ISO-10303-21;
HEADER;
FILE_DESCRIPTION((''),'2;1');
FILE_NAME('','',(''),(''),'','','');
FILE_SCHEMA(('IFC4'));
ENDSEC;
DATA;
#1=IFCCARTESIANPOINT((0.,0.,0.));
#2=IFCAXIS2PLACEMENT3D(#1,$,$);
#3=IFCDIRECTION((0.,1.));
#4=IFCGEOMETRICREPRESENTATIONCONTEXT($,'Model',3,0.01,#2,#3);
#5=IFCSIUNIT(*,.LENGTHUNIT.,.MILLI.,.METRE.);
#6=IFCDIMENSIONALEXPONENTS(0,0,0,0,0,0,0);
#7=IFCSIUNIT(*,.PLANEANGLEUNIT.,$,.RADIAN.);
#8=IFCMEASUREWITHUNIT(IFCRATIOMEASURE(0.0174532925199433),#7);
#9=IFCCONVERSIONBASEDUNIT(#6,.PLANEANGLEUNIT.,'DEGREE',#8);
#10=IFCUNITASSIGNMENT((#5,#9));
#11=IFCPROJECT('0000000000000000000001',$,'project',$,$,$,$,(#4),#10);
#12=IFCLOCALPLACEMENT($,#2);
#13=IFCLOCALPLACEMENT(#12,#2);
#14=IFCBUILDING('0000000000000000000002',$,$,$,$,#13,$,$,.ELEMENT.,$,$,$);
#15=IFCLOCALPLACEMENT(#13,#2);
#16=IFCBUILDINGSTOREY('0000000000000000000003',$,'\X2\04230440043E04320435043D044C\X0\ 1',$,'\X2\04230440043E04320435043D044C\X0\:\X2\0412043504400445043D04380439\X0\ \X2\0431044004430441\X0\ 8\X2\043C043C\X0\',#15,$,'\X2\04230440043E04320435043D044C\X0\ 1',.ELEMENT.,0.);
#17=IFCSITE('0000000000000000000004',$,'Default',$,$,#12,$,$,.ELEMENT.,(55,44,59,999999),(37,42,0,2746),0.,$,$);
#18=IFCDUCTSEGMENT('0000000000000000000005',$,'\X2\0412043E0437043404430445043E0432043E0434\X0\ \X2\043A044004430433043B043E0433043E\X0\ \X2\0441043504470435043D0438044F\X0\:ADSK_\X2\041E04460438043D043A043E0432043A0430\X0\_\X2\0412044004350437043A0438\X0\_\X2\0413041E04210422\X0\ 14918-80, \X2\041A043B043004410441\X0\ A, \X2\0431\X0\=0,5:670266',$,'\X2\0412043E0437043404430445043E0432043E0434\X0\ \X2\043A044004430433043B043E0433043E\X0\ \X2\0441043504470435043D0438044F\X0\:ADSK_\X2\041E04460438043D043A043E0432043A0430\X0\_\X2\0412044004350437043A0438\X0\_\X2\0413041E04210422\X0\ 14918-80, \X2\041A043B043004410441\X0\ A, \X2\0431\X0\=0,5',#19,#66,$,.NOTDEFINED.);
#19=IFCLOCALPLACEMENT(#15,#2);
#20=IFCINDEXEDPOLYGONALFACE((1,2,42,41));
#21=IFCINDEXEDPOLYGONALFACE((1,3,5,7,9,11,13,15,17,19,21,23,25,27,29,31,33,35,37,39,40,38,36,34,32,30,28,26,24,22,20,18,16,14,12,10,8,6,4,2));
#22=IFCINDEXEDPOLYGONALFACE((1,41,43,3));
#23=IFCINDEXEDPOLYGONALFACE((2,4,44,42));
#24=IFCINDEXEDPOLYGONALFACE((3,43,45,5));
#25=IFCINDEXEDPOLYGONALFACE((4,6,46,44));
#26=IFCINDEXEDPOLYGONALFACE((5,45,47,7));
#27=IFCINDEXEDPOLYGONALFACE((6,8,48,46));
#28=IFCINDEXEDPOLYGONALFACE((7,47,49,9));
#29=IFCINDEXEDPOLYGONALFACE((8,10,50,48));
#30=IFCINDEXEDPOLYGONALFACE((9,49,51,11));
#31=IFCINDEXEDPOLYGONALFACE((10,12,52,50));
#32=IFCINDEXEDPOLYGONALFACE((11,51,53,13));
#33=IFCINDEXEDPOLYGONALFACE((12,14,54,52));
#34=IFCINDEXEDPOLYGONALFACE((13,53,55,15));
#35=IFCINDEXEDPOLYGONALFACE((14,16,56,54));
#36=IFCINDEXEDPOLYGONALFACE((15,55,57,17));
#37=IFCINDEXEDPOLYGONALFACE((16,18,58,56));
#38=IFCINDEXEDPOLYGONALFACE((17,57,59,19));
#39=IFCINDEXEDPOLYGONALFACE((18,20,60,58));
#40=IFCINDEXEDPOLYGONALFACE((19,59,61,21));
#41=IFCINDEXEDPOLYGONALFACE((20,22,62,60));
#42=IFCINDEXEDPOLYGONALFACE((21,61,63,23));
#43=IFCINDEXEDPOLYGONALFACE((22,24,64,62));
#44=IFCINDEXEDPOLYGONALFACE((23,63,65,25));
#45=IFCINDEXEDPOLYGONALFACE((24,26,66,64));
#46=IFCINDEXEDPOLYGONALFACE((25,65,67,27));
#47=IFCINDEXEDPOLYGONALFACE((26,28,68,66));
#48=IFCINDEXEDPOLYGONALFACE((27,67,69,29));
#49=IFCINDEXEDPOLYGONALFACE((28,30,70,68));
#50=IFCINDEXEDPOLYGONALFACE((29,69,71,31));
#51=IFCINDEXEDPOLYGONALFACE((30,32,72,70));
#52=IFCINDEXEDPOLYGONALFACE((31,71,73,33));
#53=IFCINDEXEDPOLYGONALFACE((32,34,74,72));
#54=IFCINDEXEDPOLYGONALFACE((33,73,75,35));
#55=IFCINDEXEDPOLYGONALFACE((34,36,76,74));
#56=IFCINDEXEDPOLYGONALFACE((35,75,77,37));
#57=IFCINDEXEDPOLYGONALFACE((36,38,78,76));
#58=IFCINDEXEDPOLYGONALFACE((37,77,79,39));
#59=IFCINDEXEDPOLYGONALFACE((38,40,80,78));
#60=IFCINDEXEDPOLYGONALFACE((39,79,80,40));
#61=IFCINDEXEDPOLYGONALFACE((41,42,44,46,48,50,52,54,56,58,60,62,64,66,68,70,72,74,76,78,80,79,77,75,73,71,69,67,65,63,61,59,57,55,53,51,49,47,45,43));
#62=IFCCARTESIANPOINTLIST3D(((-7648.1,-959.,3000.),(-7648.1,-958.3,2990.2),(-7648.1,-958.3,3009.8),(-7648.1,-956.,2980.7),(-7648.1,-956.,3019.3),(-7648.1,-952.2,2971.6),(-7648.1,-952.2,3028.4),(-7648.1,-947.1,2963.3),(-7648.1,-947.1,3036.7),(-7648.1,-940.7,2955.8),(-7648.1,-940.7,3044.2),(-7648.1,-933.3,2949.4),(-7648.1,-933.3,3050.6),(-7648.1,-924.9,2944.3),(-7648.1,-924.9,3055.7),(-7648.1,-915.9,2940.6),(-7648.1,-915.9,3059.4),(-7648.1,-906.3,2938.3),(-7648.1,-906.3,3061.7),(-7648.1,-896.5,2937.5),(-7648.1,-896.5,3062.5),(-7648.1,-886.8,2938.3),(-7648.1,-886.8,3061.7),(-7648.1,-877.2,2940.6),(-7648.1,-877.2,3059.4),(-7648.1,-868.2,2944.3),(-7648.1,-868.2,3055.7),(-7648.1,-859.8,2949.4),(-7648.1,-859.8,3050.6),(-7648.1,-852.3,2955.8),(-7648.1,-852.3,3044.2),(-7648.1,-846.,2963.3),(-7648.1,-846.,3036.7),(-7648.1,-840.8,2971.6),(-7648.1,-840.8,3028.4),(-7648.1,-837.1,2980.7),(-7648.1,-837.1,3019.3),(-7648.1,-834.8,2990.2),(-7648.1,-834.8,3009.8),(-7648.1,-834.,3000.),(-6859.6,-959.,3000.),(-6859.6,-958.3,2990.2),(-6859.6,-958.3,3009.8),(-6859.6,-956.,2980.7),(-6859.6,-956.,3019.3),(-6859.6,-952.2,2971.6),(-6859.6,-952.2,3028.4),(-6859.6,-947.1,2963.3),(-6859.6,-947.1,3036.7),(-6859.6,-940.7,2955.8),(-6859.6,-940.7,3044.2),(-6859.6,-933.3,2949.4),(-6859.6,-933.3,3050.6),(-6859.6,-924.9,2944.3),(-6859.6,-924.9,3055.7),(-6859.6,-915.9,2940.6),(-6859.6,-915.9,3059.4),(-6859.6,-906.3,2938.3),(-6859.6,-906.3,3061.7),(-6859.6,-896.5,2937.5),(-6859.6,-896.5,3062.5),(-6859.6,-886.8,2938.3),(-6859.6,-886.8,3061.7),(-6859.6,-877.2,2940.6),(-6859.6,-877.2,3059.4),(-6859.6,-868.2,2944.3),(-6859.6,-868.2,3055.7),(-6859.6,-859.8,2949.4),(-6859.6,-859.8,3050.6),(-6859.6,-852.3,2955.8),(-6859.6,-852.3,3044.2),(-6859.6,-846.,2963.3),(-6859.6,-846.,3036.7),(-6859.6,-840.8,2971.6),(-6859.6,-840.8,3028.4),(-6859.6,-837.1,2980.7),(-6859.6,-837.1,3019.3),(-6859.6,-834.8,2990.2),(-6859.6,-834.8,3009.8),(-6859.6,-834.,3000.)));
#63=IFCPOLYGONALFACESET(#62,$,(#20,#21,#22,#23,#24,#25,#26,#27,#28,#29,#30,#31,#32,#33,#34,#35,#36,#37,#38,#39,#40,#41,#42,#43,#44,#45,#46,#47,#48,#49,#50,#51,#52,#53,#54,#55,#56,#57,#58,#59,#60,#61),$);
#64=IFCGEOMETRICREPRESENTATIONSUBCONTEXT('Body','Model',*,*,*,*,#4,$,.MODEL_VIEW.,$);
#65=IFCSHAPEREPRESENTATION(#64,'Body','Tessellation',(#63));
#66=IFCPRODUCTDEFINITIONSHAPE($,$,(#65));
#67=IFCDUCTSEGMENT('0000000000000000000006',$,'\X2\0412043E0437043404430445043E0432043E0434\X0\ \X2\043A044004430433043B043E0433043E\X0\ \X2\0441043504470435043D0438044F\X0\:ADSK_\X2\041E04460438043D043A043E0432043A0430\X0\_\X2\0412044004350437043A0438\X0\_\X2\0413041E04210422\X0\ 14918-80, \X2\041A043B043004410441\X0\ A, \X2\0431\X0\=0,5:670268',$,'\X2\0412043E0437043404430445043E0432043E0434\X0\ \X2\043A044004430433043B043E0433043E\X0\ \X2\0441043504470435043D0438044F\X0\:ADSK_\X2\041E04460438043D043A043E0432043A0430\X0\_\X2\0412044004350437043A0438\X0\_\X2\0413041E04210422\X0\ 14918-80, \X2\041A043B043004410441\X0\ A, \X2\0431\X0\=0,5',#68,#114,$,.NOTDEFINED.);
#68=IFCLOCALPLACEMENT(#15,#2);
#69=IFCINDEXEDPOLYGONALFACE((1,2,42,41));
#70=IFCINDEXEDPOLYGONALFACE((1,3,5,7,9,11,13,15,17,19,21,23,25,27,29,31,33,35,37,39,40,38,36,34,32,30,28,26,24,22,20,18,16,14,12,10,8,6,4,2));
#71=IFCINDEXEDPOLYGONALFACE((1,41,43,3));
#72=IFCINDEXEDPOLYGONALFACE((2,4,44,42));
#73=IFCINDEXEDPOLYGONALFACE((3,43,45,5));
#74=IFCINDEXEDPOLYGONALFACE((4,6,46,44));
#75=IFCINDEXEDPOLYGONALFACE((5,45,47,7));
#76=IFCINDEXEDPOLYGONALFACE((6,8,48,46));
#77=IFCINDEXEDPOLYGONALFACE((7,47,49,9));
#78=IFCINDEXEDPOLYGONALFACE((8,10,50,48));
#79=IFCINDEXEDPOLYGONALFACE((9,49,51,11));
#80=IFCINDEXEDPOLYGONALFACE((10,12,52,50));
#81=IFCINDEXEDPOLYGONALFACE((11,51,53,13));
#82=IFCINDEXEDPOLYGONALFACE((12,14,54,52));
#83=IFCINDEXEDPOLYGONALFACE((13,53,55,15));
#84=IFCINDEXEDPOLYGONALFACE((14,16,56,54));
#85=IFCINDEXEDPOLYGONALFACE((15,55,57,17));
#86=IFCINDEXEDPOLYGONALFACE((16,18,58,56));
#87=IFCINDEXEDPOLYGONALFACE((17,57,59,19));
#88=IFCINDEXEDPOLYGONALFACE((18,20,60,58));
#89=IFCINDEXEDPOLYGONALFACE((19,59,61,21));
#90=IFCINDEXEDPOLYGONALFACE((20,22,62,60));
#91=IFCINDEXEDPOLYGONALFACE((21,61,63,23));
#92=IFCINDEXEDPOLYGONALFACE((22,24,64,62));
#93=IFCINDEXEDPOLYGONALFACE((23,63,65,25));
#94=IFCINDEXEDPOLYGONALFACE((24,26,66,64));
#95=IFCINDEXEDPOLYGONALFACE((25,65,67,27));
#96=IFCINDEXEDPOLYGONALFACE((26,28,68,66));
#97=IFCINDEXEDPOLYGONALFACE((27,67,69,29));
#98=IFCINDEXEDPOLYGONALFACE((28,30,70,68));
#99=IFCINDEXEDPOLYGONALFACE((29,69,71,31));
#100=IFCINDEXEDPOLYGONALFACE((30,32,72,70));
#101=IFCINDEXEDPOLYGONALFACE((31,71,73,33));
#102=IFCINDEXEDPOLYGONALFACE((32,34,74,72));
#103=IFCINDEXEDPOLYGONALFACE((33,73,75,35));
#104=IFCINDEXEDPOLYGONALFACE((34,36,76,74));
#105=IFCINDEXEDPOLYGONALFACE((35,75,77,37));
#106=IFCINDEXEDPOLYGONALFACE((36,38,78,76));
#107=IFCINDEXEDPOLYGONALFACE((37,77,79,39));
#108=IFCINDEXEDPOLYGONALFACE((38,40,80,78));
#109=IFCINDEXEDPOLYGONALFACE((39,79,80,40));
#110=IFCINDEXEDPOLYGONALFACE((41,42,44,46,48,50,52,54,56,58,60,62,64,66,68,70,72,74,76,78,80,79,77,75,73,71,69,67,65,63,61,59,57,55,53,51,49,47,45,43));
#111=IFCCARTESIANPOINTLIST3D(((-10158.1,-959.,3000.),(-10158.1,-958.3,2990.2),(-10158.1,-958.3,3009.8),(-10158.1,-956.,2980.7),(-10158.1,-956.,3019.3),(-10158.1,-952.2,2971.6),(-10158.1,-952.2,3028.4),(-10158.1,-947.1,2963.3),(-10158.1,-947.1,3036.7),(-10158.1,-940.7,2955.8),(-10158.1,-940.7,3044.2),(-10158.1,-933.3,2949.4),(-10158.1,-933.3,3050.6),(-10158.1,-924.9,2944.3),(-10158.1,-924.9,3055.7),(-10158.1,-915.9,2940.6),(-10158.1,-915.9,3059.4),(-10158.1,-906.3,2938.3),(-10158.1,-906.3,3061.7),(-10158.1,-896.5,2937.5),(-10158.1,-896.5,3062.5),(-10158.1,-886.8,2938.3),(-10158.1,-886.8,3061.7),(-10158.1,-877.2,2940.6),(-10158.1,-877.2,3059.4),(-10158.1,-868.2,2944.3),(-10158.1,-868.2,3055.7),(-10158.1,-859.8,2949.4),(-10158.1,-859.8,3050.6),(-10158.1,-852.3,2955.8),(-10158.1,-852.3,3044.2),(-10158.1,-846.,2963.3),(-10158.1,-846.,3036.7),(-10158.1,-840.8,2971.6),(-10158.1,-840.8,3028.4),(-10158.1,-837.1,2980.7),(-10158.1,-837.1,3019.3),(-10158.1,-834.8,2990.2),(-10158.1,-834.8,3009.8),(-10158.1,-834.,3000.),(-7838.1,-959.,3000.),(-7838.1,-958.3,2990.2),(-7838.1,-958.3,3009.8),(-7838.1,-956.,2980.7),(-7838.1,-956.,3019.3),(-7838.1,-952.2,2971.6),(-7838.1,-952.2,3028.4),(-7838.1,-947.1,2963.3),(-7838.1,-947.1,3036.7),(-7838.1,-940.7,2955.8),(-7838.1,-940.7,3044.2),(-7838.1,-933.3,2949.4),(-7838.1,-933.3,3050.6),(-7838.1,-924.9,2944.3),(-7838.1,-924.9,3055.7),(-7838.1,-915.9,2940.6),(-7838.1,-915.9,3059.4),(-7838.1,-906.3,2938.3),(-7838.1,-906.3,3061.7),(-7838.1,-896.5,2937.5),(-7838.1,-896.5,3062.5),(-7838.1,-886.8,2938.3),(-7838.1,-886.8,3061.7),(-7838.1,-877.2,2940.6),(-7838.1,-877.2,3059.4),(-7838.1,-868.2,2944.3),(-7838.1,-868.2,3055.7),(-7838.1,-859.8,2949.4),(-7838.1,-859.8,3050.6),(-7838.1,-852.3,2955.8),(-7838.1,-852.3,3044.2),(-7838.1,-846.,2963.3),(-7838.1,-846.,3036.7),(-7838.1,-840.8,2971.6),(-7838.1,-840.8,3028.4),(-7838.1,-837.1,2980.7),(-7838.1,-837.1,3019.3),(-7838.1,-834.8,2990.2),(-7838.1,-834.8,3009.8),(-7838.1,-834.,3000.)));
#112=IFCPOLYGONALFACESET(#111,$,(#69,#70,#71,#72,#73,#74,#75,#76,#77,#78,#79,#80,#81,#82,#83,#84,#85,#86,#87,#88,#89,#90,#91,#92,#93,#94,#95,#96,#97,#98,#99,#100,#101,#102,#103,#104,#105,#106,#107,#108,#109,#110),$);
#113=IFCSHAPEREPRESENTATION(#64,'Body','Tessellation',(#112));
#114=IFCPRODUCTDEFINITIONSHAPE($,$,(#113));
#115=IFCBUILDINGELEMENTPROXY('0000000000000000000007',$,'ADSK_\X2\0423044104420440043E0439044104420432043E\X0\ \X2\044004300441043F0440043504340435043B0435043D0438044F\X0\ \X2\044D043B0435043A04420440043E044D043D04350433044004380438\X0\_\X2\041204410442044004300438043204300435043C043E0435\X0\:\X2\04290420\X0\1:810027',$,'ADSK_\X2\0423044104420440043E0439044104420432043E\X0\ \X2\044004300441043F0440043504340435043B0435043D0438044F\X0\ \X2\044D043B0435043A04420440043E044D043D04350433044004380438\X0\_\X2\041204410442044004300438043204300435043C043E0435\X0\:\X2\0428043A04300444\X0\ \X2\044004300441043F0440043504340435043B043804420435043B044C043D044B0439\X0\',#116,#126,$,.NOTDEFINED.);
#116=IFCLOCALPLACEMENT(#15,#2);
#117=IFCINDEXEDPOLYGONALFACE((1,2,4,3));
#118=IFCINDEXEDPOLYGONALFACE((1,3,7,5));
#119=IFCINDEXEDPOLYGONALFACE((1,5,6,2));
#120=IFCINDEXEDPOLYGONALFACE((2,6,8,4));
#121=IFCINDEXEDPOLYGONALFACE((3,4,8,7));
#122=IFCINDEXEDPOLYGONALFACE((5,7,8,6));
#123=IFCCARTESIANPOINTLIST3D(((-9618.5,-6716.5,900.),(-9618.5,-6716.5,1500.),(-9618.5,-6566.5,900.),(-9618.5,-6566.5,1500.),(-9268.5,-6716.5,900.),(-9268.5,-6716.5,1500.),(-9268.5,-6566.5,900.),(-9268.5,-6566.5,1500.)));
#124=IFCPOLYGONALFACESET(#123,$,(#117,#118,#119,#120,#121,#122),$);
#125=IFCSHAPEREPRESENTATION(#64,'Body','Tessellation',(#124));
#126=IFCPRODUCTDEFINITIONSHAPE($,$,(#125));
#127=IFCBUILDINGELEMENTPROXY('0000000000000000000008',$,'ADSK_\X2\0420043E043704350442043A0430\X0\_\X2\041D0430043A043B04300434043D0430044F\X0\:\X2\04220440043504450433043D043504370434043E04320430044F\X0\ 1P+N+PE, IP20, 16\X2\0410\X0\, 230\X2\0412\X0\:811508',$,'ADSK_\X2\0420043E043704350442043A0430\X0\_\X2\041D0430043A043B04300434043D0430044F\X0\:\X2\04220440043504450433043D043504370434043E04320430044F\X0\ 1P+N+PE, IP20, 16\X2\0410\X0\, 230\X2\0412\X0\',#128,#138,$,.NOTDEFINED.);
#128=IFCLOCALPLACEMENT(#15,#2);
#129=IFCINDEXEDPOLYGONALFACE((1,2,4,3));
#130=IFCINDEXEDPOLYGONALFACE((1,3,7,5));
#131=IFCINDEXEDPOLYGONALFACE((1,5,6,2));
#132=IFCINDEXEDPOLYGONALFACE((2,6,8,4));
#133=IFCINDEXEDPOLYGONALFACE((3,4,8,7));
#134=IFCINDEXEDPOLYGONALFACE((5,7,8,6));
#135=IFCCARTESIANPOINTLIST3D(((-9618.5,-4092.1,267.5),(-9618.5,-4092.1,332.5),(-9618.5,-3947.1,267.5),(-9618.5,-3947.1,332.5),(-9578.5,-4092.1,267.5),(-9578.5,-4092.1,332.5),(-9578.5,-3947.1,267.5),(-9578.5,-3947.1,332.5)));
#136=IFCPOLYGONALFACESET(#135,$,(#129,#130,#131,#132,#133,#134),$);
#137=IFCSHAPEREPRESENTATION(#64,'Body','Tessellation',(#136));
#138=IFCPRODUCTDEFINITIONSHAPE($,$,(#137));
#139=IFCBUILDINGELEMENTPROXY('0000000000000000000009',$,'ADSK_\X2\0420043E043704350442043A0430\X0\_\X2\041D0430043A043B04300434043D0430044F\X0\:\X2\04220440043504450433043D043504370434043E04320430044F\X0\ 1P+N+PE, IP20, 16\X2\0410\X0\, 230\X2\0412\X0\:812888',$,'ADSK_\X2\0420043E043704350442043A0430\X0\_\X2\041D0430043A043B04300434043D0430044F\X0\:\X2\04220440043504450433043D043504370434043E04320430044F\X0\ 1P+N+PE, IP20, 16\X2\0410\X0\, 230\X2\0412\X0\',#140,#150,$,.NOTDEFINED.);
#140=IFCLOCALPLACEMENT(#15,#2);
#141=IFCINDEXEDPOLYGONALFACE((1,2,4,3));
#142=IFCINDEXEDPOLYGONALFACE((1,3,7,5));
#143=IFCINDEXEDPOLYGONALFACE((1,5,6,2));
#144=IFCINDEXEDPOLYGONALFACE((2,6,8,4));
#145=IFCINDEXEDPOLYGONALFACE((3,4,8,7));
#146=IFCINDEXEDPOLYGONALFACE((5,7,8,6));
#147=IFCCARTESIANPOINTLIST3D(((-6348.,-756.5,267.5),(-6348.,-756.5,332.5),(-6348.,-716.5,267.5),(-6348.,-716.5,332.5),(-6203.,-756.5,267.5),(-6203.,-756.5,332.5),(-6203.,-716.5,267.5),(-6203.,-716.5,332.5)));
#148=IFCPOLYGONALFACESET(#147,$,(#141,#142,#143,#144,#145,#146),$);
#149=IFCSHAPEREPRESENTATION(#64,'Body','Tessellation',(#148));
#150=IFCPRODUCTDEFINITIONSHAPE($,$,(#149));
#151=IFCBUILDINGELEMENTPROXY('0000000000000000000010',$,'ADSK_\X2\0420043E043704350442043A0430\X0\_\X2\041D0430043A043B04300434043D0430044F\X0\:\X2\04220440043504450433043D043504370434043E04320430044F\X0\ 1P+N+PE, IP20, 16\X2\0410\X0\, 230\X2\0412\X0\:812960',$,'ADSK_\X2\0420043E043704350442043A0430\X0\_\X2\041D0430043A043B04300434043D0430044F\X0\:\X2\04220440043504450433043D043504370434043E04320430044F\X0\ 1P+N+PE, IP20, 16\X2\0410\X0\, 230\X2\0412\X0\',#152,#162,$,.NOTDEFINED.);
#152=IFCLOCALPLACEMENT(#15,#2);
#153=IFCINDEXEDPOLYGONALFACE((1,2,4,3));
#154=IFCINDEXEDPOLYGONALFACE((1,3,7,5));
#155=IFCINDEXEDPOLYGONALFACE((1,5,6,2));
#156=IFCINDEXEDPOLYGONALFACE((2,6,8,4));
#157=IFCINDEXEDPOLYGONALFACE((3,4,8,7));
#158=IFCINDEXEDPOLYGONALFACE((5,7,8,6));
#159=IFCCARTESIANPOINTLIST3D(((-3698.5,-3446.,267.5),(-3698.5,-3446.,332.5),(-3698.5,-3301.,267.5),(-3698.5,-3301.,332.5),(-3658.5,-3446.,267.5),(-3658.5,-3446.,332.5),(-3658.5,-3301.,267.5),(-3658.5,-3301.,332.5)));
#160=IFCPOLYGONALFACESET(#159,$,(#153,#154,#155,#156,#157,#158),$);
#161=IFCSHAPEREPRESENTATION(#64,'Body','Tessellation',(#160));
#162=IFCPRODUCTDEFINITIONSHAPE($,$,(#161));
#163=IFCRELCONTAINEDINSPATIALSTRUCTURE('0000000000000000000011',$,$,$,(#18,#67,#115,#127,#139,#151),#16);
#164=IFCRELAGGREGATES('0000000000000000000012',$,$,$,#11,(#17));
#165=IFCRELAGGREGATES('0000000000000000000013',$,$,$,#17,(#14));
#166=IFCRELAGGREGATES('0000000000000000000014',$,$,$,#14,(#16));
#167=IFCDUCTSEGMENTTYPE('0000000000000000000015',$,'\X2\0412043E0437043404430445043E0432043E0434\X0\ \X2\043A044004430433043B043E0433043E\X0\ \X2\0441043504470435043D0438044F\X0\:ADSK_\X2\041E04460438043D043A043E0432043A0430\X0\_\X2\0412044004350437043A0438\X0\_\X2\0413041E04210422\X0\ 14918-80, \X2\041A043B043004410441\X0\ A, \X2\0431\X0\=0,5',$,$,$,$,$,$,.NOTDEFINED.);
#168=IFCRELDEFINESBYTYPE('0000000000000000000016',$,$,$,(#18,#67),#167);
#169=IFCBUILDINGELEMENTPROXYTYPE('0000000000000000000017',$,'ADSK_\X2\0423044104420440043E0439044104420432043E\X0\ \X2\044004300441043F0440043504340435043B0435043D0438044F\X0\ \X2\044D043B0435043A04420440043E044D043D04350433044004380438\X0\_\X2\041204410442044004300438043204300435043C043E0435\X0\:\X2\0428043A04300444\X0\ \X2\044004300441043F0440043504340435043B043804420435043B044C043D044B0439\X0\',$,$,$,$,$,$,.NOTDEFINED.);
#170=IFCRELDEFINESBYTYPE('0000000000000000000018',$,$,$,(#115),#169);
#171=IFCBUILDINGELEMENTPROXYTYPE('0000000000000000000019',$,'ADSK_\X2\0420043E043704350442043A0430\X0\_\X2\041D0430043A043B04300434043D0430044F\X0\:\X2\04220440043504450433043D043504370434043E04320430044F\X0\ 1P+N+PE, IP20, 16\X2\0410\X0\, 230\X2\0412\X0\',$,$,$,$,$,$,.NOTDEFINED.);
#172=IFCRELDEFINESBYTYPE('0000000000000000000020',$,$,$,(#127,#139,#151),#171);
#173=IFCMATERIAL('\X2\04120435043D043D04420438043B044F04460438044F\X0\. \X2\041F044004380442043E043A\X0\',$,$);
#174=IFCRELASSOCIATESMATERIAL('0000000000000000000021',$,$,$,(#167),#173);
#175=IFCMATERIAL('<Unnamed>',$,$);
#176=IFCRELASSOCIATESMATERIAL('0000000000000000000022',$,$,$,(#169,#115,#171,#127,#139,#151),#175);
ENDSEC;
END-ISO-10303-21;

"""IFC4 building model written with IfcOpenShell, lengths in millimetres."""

from ifc_helpers import new_model, entity, si_unit, converted_unit, direction, frame, origin, place, context, subcontext, project, spatial, indexed_curve, outline, extrude, source, transform, mapped, material, type_object, type_shapes, element, save


model = new_model("IFC4")

# Units and contexts
model_context = context("Model", 3, precision=0.01, world=origin(), true_north=direction((0.0, 1.0)))
body_context = subcontext(model_context, "Body", "Model", "MODEL_VIEW")
ifc_project = project(units=[si_unit("LENGTHUNIT", "METRE", prefix="MILLI"), converted_unit("PLANEANGLEUNIT", "DEGREE", entity("IfcRatioMeasure", 0.0174532925199433), si_unit("PLANEANGLEUNIT", "RADIAN"), dimensions=[0, 0, 0, 0, 0, 0, 0])], contexts=[model_context])

# Site, building, storey
site_placement = place(None, origin())
site = spatial("IfcSite", under=ifc_project, at=site_placement, Name="Default", CompositionType="ELEMENT", RefLatitude=(55, 44, 59, 999999), RefLongitude=(37, 42, 0, 2746), RefElevation=0.0)
building_placement = place(site_placement, origin())
building = spatial("IfcBuilding", under=site, at=building_placement, CompositionType="ELEMENT")
storey_placement = place(building_placement, origin())
storey = spatial("IfcBuildingStorey", under=building, at=storey_placement, Name="Уровень 1", ObjectType="Уровень:Верхний брус 8мм", LongName="Уровень 1", CompositionType="ELEMENT", Elevation=0.0)

# Duct segments
ifc_material_1 = material(Name="Веннтиляция. Приток")
duct_segment_type = type_object("IfcDuctSegmentType", Name="Воздуховод круглого сечения:ADSK_Оцинковка_Врезки_ГОСТ 14918-80, Класс A, б=0,5", PredefinedType="NOTDEFINED", material=ifc_material_1)
duct_segment_1_placement = place(storey_placement, origin())
element("IfcDuctSegment", 1, at=duct_segment_1_placement, inside=storey, type_object=duct_segment_type, Name="Воздуховод круглого сечения:ADSK_Оцинковка_Врезки_ГОСТ 14918-80, Класс A, б=0,5:670266", ObjectType="Воздуховод круглого сечения:ADSK_Оцинковка_Врезки_ГОСТ 14918-80, Класс A, б=0,5", PredefinedType="NOTDEFINED", context=body_context, shape_type="SweptSolid", body=[
    extrude(outline(indexed_curve([(62.5, 0.0), (61.7, 9.8), (59.4, 19.3), (55.7, 28.4), (50.6, 36.7), (44.2, 44.2), (36.7, 50.6), (28.4, 55.7), (19.3, 59.4), (9.8, 61.7), (0.0, 62.5), (-9.8, 61.7), (-19.3, 59.4), (-28.4, 55.7), (-36.7, 50.6), (-44.2, 44.2), (-50.6, 36.7), (-55.7, 28.4), (-59.4, 19.3), (-61.7, 9.8), (-62.5, 0.0), (-61.7, -9.8), (-59.4, -19.3), (-55.7, -28.4), (-50.6, -36.7), (-44.2, -44.2), (-36.7, -50.6), (-28.4, -55.7), (-19.3, -59.4), (-9.8, -61.7), (0.0, -62.5), (9.8, -61.7), (19.3, -59.4), (28.4, -55.7), (36.7, -50.6), (44.2, -44.2), (50.6, -36.7), (55.7, -28.4), (59.4, -19.3), (61.7, -9.8), (62.5, 0.0)], self_intersect=False)), frame((-7648.1, -896.5, 3000.0), z_axis=(1.0, 0.0, 0.0), x_axis=(0.0, 1.0, 0.0)), (0.0, 0.0, 1.0), 788.5),
])
duct_segment_2_placement = place(storey_placement, origin())
element("IfcDuctSegment", 2, at=duct_segment_2_placement, inside=storey, type_object=duct_segment_type, Name="Воздуховод круглого сечения:ADSK_Оцинковка_Врезки_ГОСТ 14918-80, Класс A, б=0,5:670268", ObjectType="Воздуховод круглого сечения:ADSK_Оцинковка_Врезки_ГОСТ 14918-80, Класс A, б=0,5", PredefinedType="NOTDEFINED", context=body_context, shape_type="SweptSolid", body=[
    extrude(outline(indexed_curve([(62.5, 0.0), (61.7, 9.8), (59.4, 19.3), (55.7, 28.4), (50.6, 36.7), (44.2, 44.2), (36.7, 50.6), (28.4, 55.7), (19.3, 59.4), (9.8, 61.7), (0.0, 62.5), (-9.8, 61.7), (-19.3, 59.4), (-28.4, 55.7), (-36.7, 50.6), (-44.2, 44.2), (-50.6, 36.7), (-55.7, 28.4), (-59.4, 19.3), (-61.7, 9.8), (-62.5, 0.0), (-61.7, -9.8), (-59.4, -19.3), (-55.7, -28.4), (-50.6, -36.7), (-44.2, -44.2), (-36.7, -50.6), (-28.4, -55.7), (-19.3, -59.4), (-9.8, -61.7), (0.0, -62.5), (9.8, -61.7), (19.3, -59.4), (28.4, -55.7), (36.7, -50.6), (44.2, -44.2), (50.6, -36.7), (55.7, -28.4), (59.4, -19.3), (61.7, -9.8), (62.5, 0.0)], self_intersect=False)), frame((-10158.1, -896.5, 3000.0), z_axis=(1.0, 0.0, 0.0), x_axis=(0.0, 1.0, 0.0)), (0.0, 0.0, 1.0), 2320.0),
])

# Building element proxies
ifc_material_2 = material(Name="<Unnamed>")
building_element_proxy_type_1 = type_object("IfcBuildingElementProxyType", Name="ADSK_Устройство распределения электроэнегрии_Встраиваемое:Шкаф распределительный", PredefinedType="NOTDEFINED", material=ifc_material_2)
shared_shape_1 = source(origin(), body_context, "Body", "SweptSolid", [
    extrude(outline(indexed_curve([(-75.0, -175.0), (75.0, -175.0), (75.0, 175.0), (-75.0, 175.0), (-75.0, -175.0)], self_intersect=False)), frame((0.0, -75.0, -600.0), z_axis=(0.0, 0.0, 1.0), x_axis=(0.0, 1.0, 0.0)), (0.0, 0.0, 1.0), 600.0),
])
type_shapes(building_element_proxy_type_1, [shared_shape_1])
proxy_placement = place(storey_placement, frame((-9443.5, -6566.5, 1500.0)))
element("IfcBuildingElementProxy", 3, at=proxy_placement, inside=storey, type_object=building_element_proxy_type_1, material=ifc_material_2, Name="ADSK_Устройство распределения электроэнегрии_Встраиваемое:ЩР1:810027", ObjectType="ADSK_Устройство распределения электроэнегрии_Встраиваемое:Шкаф распределительный", PredefinedType="NOTDEFINED", context=body_context, shape_type="MappedRepresentation", body=[
    mapped(shared_shape_1, transform((0.0, 0.0, 0.0), scale=1.0)),
])
building_element_proxy_type_2 = type_object("IfcBuildingElementProxyType", Name="ADSK_Розетка_Накладная:Трехгнездовая 1P+N+PE, IP20, 16А, 230В", PredefinedType="NOTDEFINED", material=ifc_material_2)
shared_shape_2 = source(origin(), body_context, "Body", "SweptSolid", [
    extrude(outline(indexed_curve([(-72.5, -20.0), (72.5, -20.0), (72.5, 20.0), (-72.5, 20.0), (-72.5, -20.0)], self_intersect=False)), frame((0.0, 20.0, -32.5), z_axis=(0.0, 0.0, 1.0), x_axis=(-1.0, 0.0, 0.0)), (0.0, 0.0, 1.0), 65.0),
])
type_shapes(building_element_proxy_type_2, [shared_shape_2])
for number, where, z_axis, x_axis, name in (
    (4, (-9578.5, -4019.6, 300.0), (0.0, 0.0, 1.0), (0.0, 1.0, 0.0), "ADSK_Розетка_Накладная:Трехгнездовая 1P+N+PE, IP20, 16А, 230В:811508"),
    (5, (-6275.5, -716.5, 300.0), (0.0, 0.0, 1.0), (-1.0, 0.0, 0.0), "ADSK_Розетка_Накладная:Трехгнездовая 1P+N+PE, IP20, 16А, 230В:812888"),
    (6, (-3698.5, -3373.5, 300.0), (0.0, 0.0, 1.0), (0.0, -1.0, 0.0), "ADSK_Розетка_Накладная:Трехгнездовая 1P+N+PE, IP20, 16А, 230В:812960"),
):
    element("IfcBuildingElementProxy", number, at=place(storey_placement, frame(where, z_axis=z_axis, x_axis=x_axis)), inside=storey, type_object=building_element_proxy_type_2, material=ifc_material_2, Name=name, ObjectType="ADSK_Розетка_Накладная:Трехгнездовая 1P+N+PE, IP20, 16А, 230В", PredefinedType="NOTDEFINED", context=body_context, shape_type="MappedRepresentation", body=[
        mapped(shared_shape_2, transform((0.0, 0.0, 0.0), scale=1.0)),
    ])

save(model, "model.ifc")
